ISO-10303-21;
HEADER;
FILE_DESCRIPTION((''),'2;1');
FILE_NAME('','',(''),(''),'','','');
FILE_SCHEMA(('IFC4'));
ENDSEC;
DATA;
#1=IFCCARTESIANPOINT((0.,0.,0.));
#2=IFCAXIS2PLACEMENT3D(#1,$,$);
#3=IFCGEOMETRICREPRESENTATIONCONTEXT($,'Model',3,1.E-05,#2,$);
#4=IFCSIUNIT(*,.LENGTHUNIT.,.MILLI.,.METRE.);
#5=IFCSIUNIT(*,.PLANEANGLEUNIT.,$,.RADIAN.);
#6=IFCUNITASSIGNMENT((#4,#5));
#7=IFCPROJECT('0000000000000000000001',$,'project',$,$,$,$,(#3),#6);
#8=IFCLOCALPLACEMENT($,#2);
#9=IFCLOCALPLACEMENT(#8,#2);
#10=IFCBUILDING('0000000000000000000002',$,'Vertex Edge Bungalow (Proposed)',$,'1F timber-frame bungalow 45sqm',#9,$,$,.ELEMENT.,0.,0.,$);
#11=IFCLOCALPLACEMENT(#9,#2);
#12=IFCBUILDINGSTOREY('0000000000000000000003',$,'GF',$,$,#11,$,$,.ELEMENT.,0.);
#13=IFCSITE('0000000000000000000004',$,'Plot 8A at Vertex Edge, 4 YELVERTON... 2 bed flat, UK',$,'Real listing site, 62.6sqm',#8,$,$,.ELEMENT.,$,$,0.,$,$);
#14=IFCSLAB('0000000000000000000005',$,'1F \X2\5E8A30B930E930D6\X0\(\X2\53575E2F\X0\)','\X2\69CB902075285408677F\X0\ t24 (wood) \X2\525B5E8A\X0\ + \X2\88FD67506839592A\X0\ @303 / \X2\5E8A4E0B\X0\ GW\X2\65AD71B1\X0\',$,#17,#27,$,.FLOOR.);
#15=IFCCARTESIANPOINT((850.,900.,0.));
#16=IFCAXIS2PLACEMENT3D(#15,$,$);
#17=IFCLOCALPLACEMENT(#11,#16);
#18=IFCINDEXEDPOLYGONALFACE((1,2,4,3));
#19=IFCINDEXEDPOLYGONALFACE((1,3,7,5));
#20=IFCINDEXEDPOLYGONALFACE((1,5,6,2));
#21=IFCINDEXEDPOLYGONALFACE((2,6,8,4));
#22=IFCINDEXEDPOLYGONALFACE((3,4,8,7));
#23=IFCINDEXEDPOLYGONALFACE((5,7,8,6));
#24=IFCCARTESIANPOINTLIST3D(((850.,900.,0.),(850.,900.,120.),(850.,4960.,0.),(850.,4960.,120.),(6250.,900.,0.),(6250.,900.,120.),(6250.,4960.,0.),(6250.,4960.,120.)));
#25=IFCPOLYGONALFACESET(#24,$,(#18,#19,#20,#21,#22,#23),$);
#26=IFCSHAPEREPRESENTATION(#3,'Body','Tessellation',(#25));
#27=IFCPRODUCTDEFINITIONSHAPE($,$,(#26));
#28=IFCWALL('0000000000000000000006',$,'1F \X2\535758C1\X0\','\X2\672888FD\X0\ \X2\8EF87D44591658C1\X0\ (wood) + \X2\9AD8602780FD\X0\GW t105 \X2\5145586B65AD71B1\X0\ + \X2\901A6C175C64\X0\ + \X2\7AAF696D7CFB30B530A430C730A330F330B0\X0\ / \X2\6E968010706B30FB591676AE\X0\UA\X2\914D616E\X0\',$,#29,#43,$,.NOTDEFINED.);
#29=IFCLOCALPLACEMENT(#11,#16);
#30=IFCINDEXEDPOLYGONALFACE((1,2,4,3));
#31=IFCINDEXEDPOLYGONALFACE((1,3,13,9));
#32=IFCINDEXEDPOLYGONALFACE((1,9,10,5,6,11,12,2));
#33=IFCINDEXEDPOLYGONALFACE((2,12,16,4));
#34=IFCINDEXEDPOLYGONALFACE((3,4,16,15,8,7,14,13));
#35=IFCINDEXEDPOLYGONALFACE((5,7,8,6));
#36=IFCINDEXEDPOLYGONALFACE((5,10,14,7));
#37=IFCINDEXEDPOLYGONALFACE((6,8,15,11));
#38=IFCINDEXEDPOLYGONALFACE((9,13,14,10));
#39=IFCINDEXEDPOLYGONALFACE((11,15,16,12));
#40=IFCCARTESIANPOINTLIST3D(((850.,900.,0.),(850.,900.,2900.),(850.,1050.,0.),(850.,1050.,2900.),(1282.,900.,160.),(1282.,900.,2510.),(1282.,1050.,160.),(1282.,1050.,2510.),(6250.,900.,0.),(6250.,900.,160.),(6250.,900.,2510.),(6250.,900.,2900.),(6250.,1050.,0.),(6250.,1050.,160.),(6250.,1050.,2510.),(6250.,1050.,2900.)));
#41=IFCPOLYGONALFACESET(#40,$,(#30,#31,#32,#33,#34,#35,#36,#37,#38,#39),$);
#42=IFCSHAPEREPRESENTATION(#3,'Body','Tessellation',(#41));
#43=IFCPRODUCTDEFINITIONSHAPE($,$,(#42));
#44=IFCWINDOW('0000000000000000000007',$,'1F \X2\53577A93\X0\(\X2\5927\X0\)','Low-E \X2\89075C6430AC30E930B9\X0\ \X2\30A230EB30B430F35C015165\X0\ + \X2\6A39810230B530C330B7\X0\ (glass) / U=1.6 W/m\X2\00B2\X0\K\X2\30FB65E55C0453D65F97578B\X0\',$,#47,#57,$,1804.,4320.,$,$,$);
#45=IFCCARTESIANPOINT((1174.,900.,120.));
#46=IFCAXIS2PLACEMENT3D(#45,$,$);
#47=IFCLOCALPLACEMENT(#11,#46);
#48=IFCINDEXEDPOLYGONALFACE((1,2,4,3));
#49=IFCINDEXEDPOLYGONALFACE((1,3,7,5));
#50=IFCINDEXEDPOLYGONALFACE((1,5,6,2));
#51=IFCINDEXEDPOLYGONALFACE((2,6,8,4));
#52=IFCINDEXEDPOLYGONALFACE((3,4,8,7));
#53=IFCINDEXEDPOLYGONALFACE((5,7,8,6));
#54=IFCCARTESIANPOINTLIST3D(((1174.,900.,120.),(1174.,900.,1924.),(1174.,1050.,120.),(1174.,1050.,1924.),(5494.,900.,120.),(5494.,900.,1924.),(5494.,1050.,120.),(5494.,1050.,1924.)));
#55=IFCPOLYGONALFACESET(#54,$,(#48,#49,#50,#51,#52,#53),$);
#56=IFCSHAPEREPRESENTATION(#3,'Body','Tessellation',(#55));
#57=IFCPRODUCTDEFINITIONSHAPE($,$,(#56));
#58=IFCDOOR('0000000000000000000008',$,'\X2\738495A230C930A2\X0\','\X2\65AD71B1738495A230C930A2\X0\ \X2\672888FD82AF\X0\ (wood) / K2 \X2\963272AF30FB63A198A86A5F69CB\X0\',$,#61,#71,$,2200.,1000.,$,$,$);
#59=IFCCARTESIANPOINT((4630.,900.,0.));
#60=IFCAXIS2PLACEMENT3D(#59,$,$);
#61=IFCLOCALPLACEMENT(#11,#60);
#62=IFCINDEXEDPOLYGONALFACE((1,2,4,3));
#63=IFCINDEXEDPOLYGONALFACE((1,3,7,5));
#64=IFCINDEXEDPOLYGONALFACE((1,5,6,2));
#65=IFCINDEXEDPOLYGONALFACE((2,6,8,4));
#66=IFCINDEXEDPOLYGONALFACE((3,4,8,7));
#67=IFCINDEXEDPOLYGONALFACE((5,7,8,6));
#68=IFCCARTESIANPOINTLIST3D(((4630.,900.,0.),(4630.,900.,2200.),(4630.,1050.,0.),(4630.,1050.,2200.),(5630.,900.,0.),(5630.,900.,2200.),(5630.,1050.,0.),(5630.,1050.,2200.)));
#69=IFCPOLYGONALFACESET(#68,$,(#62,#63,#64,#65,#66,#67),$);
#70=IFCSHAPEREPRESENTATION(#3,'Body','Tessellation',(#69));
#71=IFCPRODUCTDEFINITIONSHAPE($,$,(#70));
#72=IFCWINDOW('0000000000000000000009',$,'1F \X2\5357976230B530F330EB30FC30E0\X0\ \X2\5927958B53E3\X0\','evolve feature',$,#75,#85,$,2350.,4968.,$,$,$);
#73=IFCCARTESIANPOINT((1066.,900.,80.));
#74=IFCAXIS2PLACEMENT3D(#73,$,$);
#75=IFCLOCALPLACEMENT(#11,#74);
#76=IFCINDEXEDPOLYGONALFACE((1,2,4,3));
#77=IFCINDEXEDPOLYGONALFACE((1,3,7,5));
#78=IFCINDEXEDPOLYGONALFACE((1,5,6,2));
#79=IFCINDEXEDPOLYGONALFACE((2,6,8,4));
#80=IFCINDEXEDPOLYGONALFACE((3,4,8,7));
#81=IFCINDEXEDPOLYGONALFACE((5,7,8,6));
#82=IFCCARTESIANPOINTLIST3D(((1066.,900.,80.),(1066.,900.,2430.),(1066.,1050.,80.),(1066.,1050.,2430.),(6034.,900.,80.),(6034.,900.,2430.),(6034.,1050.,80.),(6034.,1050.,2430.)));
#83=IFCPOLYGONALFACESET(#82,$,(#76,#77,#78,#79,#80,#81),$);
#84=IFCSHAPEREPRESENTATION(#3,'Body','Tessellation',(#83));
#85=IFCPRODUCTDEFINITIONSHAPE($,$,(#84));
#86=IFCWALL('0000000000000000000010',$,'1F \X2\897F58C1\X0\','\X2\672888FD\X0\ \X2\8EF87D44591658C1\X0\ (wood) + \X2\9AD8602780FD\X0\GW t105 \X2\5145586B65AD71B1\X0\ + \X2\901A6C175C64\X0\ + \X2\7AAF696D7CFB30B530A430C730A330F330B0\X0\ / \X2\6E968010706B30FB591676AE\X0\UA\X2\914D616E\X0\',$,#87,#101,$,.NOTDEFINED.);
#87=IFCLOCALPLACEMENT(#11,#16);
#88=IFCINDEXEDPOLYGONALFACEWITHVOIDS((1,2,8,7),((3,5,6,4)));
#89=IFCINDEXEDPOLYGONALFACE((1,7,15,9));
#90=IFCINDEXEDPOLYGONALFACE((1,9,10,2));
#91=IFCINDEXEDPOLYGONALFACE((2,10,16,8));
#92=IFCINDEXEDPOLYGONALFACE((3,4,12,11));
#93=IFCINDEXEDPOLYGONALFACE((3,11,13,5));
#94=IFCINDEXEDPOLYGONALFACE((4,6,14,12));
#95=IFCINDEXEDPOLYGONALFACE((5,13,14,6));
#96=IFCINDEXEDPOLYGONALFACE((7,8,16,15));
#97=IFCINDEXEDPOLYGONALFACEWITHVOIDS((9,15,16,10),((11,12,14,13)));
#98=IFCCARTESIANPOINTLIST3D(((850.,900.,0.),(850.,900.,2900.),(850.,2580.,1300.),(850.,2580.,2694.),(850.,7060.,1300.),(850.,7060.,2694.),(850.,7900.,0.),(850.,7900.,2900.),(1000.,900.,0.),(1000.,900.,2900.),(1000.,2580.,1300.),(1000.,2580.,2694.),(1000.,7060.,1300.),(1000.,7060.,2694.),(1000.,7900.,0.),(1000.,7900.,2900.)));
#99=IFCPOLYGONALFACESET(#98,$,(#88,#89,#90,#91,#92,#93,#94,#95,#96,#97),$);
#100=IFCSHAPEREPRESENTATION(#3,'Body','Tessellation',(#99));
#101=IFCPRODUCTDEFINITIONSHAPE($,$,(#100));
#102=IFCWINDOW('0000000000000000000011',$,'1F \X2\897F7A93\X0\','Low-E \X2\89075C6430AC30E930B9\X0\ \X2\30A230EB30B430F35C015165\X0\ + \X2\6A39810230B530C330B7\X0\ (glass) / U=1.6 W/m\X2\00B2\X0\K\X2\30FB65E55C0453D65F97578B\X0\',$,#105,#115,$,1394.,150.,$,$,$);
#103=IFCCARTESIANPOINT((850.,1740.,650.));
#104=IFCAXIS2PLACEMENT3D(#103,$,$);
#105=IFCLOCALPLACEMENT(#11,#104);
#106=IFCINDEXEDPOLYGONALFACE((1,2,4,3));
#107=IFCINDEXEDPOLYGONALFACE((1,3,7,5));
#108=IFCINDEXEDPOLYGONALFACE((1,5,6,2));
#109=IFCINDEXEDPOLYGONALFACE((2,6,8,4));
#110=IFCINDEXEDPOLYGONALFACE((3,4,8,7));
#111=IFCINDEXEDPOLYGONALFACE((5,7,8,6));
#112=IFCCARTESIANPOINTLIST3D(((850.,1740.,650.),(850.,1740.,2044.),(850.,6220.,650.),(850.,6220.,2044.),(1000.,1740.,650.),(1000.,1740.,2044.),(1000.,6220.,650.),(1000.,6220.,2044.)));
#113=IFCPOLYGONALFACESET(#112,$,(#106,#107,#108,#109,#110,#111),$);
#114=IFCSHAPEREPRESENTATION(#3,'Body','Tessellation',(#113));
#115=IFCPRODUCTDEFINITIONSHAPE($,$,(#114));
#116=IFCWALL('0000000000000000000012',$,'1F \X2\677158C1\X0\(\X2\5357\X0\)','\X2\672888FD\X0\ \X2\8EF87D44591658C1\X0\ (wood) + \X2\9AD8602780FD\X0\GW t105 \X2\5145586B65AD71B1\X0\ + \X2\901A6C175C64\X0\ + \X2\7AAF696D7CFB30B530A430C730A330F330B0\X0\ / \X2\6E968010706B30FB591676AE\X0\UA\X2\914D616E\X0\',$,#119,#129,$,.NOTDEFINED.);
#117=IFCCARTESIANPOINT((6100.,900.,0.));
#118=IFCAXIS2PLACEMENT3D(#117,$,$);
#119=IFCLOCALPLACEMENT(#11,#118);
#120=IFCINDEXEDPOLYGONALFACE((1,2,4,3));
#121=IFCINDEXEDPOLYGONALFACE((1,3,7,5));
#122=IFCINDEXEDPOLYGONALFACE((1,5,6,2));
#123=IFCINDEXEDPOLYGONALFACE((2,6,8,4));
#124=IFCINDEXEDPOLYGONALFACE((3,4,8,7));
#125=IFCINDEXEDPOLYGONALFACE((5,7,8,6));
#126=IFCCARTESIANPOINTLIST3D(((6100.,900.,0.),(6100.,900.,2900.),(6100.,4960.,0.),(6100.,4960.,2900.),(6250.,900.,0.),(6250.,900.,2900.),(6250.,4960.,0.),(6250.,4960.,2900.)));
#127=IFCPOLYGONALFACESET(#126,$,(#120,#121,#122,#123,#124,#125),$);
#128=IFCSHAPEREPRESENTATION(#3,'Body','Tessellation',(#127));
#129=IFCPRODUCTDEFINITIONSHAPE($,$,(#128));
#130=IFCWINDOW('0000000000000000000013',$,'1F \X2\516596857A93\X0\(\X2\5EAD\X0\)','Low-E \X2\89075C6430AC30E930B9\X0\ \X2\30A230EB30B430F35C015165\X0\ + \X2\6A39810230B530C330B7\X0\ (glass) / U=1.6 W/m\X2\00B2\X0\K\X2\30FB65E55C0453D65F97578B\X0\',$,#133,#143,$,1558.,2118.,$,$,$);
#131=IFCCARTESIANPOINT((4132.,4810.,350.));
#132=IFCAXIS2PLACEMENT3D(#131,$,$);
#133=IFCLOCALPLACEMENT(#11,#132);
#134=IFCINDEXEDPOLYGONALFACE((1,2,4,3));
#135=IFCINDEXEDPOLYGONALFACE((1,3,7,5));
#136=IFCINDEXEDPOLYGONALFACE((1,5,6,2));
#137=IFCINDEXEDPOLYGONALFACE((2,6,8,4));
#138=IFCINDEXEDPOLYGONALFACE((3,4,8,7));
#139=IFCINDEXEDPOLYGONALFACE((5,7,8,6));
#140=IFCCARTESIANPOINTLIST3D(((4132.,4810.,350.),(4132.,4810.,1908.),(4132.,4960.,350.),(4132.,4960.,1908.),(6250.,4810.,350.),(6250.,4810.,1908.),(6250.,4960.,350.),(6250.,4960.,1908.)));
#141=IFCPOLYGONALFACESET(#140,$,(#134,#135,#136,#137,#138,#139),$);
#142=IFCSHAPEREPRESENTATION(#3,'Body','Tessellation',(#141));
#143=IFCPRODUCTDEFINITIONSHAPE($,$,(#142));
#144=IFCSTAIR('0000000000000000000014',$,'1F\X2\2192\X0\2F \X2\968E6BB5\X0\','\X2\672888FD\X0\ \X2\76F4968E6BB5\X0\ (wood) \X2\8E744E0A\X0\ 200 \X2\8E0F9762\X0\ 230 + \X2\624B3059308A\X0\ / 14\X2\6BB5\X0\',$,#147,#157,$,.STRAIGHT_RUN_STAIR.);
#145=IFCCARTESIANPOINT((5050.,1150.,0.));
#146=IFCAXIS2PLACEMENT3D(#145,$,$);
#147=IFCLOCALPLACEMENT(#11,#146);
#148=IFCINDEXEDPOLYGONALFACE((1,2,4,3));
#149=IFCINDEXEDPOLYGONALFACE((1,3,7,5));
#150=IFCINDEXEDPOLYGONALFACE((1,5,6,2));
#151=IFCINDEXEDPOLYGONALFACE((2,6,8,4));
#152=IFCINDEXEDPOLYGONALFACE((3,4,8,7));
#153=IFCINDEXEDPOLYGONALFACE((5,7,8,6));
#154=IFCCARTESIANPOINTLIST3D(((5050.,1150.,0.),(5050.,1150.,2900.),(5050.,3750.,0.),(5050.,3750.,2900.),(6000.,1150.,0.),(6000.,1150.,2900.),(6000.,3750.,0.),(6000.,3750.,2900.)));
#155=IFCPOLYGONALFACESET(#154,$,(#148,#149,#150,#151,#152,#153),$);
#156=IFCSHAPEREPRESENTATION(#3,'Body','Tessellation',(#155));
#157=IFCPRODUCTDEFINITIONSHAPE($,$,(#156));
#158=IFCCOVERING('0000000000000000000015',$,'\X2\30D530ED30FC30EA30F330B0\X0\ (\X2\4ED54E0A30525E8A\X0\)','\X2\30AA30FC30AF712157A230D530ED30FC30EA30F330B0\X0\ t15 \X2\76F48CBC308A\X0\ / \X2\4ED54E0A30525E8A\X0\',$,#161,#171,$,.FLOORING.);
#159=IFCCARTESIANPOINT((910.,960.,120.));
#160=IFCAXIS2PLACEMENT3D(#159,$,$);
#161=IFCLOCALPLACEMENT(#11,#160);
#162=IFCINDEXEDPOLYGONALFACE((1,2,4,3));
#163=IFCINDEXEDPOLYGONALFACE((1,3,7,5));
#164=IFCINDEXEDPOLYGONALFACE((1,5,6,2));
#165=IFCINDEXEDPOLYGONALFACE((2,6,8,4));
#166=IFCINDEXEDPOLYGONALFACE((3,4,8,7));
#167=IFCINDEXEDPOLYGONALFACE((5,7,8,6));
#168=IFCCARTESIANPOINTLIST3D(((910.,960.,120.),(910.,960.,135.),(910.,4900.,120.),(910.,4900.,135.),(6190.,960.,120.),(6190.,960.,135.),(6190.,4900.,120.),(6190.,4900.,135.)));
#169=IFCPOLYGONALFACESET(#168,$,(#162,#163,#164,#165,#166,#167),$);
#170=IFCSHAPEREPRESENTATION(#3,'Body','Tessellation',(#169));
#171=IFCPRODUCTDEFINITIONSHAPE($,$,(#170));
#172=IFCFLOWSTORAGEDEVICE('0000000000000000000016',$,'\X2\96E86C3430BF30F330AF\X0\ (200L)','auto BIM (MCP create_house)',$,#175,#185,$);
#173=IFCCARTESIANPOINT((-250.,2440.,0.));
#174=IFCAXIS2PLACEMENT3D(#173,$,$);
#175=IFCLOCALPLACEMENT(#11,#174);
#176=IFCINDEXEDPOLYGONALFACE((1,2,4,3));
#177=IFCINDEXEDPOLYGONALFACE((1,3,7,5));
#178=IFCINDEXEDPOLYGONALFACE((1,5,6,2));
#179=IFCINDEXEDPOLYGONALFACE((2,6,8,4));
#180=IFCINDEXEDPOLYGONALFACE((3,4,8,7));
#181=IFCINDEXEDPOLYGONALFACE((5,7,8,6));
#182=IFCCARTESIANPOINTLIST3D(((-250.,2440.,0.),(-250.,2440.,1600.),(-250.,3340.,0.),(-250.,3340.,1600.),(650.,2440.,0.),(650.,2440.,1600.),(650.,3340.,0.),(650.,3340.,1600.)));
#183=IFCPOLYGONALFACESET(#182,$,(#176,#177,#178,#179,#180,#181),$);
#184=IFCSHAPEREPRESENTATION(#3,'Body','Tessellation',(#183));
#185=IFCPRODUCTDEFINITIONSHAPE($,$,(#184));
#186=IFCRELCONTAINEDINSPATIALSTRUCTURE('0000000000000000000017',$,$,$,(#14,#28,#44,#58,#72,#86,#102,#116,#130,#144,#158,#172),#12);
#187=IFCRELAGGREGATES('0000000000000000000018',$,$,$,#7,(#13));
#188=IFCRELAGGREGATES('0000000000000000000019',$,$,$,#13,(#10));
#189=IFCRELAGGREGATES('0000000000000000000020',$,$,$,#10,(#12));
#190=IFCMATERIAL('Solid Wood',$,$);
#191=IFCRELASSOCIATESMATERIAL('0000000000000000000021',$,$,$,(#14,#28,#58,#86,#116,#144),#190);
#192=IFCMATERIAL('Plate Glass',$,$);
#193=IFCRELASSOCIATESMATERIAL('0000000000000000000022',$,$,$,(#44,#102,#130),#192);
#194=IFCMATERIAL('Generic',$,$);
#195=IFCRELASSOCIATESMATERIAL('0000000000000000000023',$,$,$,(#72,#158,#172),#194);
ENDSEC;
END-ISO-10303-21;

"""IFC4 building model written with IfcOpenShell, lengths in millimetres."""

from ifc_helpers import new_model, si_unit, frame, frame_2d, origin, place, context, project, spatial, rectangle, extrude, material, element, fill, save


model = new_model("IFC4")

# Units and contexts
model_context = context("Model", 3, precision=1e-05, world=origin())
ifc_project = project(units=[si_unit("LENGTHUNIT", "METRE", prefix="MILLI"), si_unit("PLANEANGLEUNIT", "RADIAN")], contexts=[model_context])

# Site, building, storey
site_placement = place(None, origin())
site = spatial("IfcSite", under=ifc_project, at=site_placement, Name="Plot 8A at Vertex Edge, 4 YELVERTON... 2 bed flat, UK", ObjectType="Real listing site, 62.6sqm", CompositionType="ELEMENT", RefElevation=0.0)
building_placement = place(site_placement, origin())
building = spatial("IfcBuilding", under=site, at=building_placement, Name="Vertex Edge Bungalow (Proposed)", ObjectType="1F timber-frame bungalow 45sqm", CompositionType="ELEMENT", ElevationOfRefHeight=0.0, ElevationOfTerrain=0.0)
storey_placement = place(building_placement, origin())
storey = spatial("IfcBuildingStorey", under=building, at=storey_placement, Name="GF", CompositionType="ELEMENT", Elevation=0.0)

# Slab
ifc_material_1 = material(Name="Solid Wood")
slab_1_placement = place(storey_placement, frame((850.0, 900.0, 0.0)))
element("IfcSlab", 1, at=slab_1_placement, inside=storey, material=ifc_material_1, Name="1F 床スラブ(南帯)", Description="構造用合板 t24 (wood) 剛床 + 製材根太 @303 / 床下 GW断熱", PredefinedType="FLOOR", context=model_context, shape_type="SweptSolid", body=[
    extrude(rectangle(XDim=5400.0, YDim=4060.0, at=frame_2d((2700.0, 2030.0))), frame((850.0, 900.0, 0.0)), (0.0, 0.0, 1.0), 120.0),
])

# Wall, openings, windows, door
wall_1_placement = place(storey_placement, frame((850.0, 900.0, 0.0)))
wall_1 = element("IfcWall", 2, at=wall_1_placement, inside=storey, material=ifc_material_1, Name="1F 南壁", Description="木製 軸組外壁 (wood) + 高性能GW t105 充填断熱 + 通気層 + 窯業系サイディング / 準耐火・外皮UA配慮", PredefinedType="NOTDEFINED", context=model_context, shape_type="SweptSolid", body=[
    extrude(rectangle(XDim=5400.0, YDim=150.0, at=frame_2d((2700.0, 75.0))), frame((850.0, 900.0, 0.0)), (0.0, 0.0, 1.0), 2900.0),
])
opening_1_placement = place(storey_placement, frame((1174.0, 900.0, 120.0)))
opening_1 = element("IfcOpeningElement", 3, at=opening_1_placement, cuts=wall_1, PredefinedType="NOTDEFINED", context=model_context, shape_type="SweptSolid", body=[
    extrude(rectangle(XDim=4320.0, YDim=150.0, at=frame_2d((2160.0, 75.0))), frame((1174.0, 900.0, 120.0)), (0.0, 0.0, 1.0), 1804.0),
])
opening_2_placement = place(storey_placement, frame((4630.0, 900.0, 0.0)))
opening_2 = element("IfcOpeningElement", 4, at=opening_2_placement, cuts=wall_1, PredefinedType="NOTDEFINED", context=model_context, shape_type="SweptSolid", body=[
    extrude(rectangle(XDim=1000.0, YDim=150.0, at=frame_2d((500.0, 75.0))), frame((4630.0, 900.0, 0.0)), (0.0, 0.0, 1.0), 2200.0),
])
opening_3_placement = place(storey_placement, frame((1066.0, 900.0, 80.0)))
opening_3 = element("IfcOpeningElement", 5, at=opening_3_placement, cuts=wall_1, PredefinedType="NOTDEFINED", context=model_context, shape_type="SweptSolid", body=[
    extrude(rectangle(XDim=4968.0, YDim=150.0, at=frame_2d((2484.0, 75.0))), frame((1066.0, 900.0, 80.0)), (0.0, 0.0, 1.0), 2350.0),
])
ifc_material_2 = material(Name="Plate Glass")
window_1_placement = place(storey_placement, frame((1174.0, 900.0, 120.0)))
window_1 = element("IfcWindow", 6, at=window_1_placement, inside=storey, material=ifc_material_2, Name="1F 南窓(大)", Description="Low-E 複層ガラス アルゴン封入 + 樹脂サッシ (glass) / U=1.6 W/m²K・日射取得型", OverallHeight=1804.0, OverallWidth=4320.0, context=model_context, shape_type="SweptSolid", body=[
    extrude(rectangle(XDim=4320.0, YDim=150.0, at=frame_2d((2160.0, 75.0))), frame((1174.0, 900.0, 120.0)), (0.0, 0.0, 1.0), 1804.0),
])
fill(opening_1, window_1)
door_1_placement = place(storey_placement, frame((4630.0, 900.0, 0.0)))
door_1 = element("IfcDoor", 7, at=door_1_placement, inside=storey, material=ifc_material_1, Name="玄関ドア", Description="断熱玄関ドア 木製芯 (wood) / K2 防犯・採風機構", OverallHeight=2200.0, OverallWidth=1000.0, context=model_context, shape_type="SweptSolid", body=[
    extrude(rectangle(XDim=1000.0, YDim=150.0, at=frame_2d((500.0, 75.0))), frame((4630.0, 900.0, 0.0)), (0.0, 0.0, 1.0), 2200.0),
])
fill(opening_2, door_1)
ifc_material_3 = material(Name="Generic")
window_2_placement = place(storey_placement, frame((1066.0, 900.0, 80.0)))
window_2 = element("IfcWindow", 8, at=window_2_placement, inside=storey, material=ifc_material_3, Name="1F 南面サンルーム 大開口", Description="evolve feature", OverallHeight=2350.0, OverallWidth=4968.0, context=model_context, shape_type="SweptSolid", body=[
    extrude(rectangle(XDim=4968.0, YDim=150.0, at=frame_2d((2484.0, 75.0))), frame((1066.0, 900.0, 80.0)), (0.0, 0.0, 1.0), 2350.0),
])
fill(opening_3, window_2)

# Walls, openings, windows
wall_2_placement = place(storey_placement, frame((850.0, 900.0, 0.0)))
wall_2 = element("IfcWall", 9, at=wall_2_placement, inside=storey, material=ifc_material_1, Name="1F 西壁", Description="木製 軸組外壁 (wood) + 高性能GW t105 充填断熱 + 通気層 + 窯業系サイディング / 準耐火・外皮UA配慮", PredefinedType="NOTDEFINED", context=model_context, shape_type="SweptSolid", body=[
    extrude(rectangle(XDim=150.0, YDim=7000.0, at=frame_2d((75.0, 3500.0))), frame((850.0, 900.0, 0.0)), (0.0, 0.0, 1.0), 2900.0),
])
opening_4_placement = place(storey_placement, frame((850.0, 1740.0, 650.0)))
opening_4 = element("IfcOpeningElement", 10, at=opening_4_placement, cuts=wall_2, PredefinedType="NOTDEFINED", context=model_context, shape_type="SweptSolid", body=[
    extrude(rectangle(XDim=150.0, YDim=4480.0, at=frame_2d((75.0, 2240.0))), frame((850.0, 1740.0, 650.0)), (0.0, 0.0, 1.0), 1394.0),
])
window_3_placement = place(storey_placement, frame((850.0, 1740.0, 650.0)))
window_3 = element("IfcWindow", 11, at=window_3_placement, inside=storey, material=ifc_material_2, Name="1F 西窓", Description="Low-E 複層ガラス アルゴン封入 + 樹脂サッシ (glass) / U=1.6 W/m²K・日射取得型", OverallHeight=1394.0, OverallWidth=150.0, context=model_context, shape_type="SweptSolid", body=[
    extrude(rectangle(XDim=150.0, YDim=4480.0, at=frame_2d((75.0, 2240.0))), frame((850.0, 1740.0, 650.0)), (0.0, 0.0, 1.0), 1394.0),
])
fill(opening_4, window_3)
wall_3_placement = place(storey_placement, frame((6100.0, 900.0, 0.0)))
wall_3 = element("IfcWall", 12, at=wall_3_placement, inside=storey, material=ifc_material_1, Name="1F 東壁(南)", Description="木製 軸組外壁 (wood) + 高性能GW t105 充填断熱 + 通気層 + 窯業系サイディング / 準耐火・外皮UA配慮", PredefinedType="NOTDEFINED", context=model_context, shape_type="SweptSolid", body=[
    extrude(rectangle(XDim=150.0, YDim=4060.0, at=frame_2d((75.0, 2030.0))), frame((6100.0, 900.0, 0.0)), (0.0, 0.0, 1.0), 2900.0),
])
opening_5_placement = place(storey_placement, frame((4132.0, 4810.0, 350.0)))
opening_5 = element("IfcOpeningElement", 13, at=opening_5_placement, cuts=wall_3, PredefinedType="NOTDEFINED", context=model_context, shape_type="SweptSolid", body=[
    extrude(rectangle(XDim=2118.0, YDim=150.0, at=frame_2d((1059.0, 75.0))), frame((4132.0, 4810.0, 350.0)), (0.0, 0.0, 1.0), 1558.0),
])
window_4_placement = place(storey_placement, frame((4132.0, 4810.0, 350.0)))
window_4 = element("IfcWindow", 14, at=window_4_placement, inside=storey, material=ifc_material_2, Name="1F 入隅窓(庭)", Description="Low-E 複層ガラス アルゴン封入 + 樹脂サッシ (glass) / U=1.6 W/m²K・日射取得型", OverallHeight=1558.0, OverallWidth=2118.0, context=model_context, shape_type="SweptSolid", body=[
    extrude(rectangle(XDim=2118.0, YDim=150.0, at=frame_2d((1059.0, 75.0))), frame((4132.0, 4810.0, 350.0)), (0.0, 0.0, 1.0), 1558.0),
])
fill(opening_5, window_4)

# Stair
stair_placement = place(storey_placement, frame((5050.0, 1150.0, 0.0)))
element("IfcStair", 15, at=stair_placement, inside=storey, material=ifc_material_1, Name="1F→2F 階段", Description="木製 直階段 (wood) 蹴上 200 踏面 230 + 手すり / 14段", PredefinedType="STRAIGHT_RUN_STAIR", context=model_context, shape_type="SweptSolid", body=[
    extrude(rectangle(XDim=950.0, YDim=2600.0, at=frame_2d((475.0, 1300.0))), frame((5050.0, 1150.0, 0.0)), (0.0, 0.0, 1.0), 2900.0),
])

# Covering
covering_placement = place(storey_placement, frame((910.0, 960.0, 120.0)))
element("IfcCovering", 16, at=covering_placement, inside=storey, material=ifc_material_3, Name="フローリング (仕上げ床)", Description="オーク無垢フローリング t15 直貼り / 仕上げ床", PredefinedType="FLOORING", context=model_context, shape_type="SweptSolid", body=[
    extrude(rectangle(XDim=5280.0, YDim=3940.0, at=frame_2d((2640.0, 1970.0))), frame((910.0, 960.0, 120.0)), (0.0, 0.0, 1.0), 15.0),
])

# Flow storage device
flow_storage_device_placement = place(storey_placement, frame((-250.0, 2440.0, 0.0)))
element("IfcFlowStorageDevice", 17, at=flow_storage_device_placement, inside=storey, material=ifc_material_3, Name="雨水タンク (200L)", Description="auto BIM (MCP create_house)", context=model_context, shape_type="SweptSolid", body=[
    extrude(rectangle(XDim=900.0, YDim=900.0, at=frame_2d((450.0, 450.0))), frame((-250.0, 2440.0, 0.0)), (0.0, 0.0, 1.0), 1600.0),
])

save(model, "model.ifc")
